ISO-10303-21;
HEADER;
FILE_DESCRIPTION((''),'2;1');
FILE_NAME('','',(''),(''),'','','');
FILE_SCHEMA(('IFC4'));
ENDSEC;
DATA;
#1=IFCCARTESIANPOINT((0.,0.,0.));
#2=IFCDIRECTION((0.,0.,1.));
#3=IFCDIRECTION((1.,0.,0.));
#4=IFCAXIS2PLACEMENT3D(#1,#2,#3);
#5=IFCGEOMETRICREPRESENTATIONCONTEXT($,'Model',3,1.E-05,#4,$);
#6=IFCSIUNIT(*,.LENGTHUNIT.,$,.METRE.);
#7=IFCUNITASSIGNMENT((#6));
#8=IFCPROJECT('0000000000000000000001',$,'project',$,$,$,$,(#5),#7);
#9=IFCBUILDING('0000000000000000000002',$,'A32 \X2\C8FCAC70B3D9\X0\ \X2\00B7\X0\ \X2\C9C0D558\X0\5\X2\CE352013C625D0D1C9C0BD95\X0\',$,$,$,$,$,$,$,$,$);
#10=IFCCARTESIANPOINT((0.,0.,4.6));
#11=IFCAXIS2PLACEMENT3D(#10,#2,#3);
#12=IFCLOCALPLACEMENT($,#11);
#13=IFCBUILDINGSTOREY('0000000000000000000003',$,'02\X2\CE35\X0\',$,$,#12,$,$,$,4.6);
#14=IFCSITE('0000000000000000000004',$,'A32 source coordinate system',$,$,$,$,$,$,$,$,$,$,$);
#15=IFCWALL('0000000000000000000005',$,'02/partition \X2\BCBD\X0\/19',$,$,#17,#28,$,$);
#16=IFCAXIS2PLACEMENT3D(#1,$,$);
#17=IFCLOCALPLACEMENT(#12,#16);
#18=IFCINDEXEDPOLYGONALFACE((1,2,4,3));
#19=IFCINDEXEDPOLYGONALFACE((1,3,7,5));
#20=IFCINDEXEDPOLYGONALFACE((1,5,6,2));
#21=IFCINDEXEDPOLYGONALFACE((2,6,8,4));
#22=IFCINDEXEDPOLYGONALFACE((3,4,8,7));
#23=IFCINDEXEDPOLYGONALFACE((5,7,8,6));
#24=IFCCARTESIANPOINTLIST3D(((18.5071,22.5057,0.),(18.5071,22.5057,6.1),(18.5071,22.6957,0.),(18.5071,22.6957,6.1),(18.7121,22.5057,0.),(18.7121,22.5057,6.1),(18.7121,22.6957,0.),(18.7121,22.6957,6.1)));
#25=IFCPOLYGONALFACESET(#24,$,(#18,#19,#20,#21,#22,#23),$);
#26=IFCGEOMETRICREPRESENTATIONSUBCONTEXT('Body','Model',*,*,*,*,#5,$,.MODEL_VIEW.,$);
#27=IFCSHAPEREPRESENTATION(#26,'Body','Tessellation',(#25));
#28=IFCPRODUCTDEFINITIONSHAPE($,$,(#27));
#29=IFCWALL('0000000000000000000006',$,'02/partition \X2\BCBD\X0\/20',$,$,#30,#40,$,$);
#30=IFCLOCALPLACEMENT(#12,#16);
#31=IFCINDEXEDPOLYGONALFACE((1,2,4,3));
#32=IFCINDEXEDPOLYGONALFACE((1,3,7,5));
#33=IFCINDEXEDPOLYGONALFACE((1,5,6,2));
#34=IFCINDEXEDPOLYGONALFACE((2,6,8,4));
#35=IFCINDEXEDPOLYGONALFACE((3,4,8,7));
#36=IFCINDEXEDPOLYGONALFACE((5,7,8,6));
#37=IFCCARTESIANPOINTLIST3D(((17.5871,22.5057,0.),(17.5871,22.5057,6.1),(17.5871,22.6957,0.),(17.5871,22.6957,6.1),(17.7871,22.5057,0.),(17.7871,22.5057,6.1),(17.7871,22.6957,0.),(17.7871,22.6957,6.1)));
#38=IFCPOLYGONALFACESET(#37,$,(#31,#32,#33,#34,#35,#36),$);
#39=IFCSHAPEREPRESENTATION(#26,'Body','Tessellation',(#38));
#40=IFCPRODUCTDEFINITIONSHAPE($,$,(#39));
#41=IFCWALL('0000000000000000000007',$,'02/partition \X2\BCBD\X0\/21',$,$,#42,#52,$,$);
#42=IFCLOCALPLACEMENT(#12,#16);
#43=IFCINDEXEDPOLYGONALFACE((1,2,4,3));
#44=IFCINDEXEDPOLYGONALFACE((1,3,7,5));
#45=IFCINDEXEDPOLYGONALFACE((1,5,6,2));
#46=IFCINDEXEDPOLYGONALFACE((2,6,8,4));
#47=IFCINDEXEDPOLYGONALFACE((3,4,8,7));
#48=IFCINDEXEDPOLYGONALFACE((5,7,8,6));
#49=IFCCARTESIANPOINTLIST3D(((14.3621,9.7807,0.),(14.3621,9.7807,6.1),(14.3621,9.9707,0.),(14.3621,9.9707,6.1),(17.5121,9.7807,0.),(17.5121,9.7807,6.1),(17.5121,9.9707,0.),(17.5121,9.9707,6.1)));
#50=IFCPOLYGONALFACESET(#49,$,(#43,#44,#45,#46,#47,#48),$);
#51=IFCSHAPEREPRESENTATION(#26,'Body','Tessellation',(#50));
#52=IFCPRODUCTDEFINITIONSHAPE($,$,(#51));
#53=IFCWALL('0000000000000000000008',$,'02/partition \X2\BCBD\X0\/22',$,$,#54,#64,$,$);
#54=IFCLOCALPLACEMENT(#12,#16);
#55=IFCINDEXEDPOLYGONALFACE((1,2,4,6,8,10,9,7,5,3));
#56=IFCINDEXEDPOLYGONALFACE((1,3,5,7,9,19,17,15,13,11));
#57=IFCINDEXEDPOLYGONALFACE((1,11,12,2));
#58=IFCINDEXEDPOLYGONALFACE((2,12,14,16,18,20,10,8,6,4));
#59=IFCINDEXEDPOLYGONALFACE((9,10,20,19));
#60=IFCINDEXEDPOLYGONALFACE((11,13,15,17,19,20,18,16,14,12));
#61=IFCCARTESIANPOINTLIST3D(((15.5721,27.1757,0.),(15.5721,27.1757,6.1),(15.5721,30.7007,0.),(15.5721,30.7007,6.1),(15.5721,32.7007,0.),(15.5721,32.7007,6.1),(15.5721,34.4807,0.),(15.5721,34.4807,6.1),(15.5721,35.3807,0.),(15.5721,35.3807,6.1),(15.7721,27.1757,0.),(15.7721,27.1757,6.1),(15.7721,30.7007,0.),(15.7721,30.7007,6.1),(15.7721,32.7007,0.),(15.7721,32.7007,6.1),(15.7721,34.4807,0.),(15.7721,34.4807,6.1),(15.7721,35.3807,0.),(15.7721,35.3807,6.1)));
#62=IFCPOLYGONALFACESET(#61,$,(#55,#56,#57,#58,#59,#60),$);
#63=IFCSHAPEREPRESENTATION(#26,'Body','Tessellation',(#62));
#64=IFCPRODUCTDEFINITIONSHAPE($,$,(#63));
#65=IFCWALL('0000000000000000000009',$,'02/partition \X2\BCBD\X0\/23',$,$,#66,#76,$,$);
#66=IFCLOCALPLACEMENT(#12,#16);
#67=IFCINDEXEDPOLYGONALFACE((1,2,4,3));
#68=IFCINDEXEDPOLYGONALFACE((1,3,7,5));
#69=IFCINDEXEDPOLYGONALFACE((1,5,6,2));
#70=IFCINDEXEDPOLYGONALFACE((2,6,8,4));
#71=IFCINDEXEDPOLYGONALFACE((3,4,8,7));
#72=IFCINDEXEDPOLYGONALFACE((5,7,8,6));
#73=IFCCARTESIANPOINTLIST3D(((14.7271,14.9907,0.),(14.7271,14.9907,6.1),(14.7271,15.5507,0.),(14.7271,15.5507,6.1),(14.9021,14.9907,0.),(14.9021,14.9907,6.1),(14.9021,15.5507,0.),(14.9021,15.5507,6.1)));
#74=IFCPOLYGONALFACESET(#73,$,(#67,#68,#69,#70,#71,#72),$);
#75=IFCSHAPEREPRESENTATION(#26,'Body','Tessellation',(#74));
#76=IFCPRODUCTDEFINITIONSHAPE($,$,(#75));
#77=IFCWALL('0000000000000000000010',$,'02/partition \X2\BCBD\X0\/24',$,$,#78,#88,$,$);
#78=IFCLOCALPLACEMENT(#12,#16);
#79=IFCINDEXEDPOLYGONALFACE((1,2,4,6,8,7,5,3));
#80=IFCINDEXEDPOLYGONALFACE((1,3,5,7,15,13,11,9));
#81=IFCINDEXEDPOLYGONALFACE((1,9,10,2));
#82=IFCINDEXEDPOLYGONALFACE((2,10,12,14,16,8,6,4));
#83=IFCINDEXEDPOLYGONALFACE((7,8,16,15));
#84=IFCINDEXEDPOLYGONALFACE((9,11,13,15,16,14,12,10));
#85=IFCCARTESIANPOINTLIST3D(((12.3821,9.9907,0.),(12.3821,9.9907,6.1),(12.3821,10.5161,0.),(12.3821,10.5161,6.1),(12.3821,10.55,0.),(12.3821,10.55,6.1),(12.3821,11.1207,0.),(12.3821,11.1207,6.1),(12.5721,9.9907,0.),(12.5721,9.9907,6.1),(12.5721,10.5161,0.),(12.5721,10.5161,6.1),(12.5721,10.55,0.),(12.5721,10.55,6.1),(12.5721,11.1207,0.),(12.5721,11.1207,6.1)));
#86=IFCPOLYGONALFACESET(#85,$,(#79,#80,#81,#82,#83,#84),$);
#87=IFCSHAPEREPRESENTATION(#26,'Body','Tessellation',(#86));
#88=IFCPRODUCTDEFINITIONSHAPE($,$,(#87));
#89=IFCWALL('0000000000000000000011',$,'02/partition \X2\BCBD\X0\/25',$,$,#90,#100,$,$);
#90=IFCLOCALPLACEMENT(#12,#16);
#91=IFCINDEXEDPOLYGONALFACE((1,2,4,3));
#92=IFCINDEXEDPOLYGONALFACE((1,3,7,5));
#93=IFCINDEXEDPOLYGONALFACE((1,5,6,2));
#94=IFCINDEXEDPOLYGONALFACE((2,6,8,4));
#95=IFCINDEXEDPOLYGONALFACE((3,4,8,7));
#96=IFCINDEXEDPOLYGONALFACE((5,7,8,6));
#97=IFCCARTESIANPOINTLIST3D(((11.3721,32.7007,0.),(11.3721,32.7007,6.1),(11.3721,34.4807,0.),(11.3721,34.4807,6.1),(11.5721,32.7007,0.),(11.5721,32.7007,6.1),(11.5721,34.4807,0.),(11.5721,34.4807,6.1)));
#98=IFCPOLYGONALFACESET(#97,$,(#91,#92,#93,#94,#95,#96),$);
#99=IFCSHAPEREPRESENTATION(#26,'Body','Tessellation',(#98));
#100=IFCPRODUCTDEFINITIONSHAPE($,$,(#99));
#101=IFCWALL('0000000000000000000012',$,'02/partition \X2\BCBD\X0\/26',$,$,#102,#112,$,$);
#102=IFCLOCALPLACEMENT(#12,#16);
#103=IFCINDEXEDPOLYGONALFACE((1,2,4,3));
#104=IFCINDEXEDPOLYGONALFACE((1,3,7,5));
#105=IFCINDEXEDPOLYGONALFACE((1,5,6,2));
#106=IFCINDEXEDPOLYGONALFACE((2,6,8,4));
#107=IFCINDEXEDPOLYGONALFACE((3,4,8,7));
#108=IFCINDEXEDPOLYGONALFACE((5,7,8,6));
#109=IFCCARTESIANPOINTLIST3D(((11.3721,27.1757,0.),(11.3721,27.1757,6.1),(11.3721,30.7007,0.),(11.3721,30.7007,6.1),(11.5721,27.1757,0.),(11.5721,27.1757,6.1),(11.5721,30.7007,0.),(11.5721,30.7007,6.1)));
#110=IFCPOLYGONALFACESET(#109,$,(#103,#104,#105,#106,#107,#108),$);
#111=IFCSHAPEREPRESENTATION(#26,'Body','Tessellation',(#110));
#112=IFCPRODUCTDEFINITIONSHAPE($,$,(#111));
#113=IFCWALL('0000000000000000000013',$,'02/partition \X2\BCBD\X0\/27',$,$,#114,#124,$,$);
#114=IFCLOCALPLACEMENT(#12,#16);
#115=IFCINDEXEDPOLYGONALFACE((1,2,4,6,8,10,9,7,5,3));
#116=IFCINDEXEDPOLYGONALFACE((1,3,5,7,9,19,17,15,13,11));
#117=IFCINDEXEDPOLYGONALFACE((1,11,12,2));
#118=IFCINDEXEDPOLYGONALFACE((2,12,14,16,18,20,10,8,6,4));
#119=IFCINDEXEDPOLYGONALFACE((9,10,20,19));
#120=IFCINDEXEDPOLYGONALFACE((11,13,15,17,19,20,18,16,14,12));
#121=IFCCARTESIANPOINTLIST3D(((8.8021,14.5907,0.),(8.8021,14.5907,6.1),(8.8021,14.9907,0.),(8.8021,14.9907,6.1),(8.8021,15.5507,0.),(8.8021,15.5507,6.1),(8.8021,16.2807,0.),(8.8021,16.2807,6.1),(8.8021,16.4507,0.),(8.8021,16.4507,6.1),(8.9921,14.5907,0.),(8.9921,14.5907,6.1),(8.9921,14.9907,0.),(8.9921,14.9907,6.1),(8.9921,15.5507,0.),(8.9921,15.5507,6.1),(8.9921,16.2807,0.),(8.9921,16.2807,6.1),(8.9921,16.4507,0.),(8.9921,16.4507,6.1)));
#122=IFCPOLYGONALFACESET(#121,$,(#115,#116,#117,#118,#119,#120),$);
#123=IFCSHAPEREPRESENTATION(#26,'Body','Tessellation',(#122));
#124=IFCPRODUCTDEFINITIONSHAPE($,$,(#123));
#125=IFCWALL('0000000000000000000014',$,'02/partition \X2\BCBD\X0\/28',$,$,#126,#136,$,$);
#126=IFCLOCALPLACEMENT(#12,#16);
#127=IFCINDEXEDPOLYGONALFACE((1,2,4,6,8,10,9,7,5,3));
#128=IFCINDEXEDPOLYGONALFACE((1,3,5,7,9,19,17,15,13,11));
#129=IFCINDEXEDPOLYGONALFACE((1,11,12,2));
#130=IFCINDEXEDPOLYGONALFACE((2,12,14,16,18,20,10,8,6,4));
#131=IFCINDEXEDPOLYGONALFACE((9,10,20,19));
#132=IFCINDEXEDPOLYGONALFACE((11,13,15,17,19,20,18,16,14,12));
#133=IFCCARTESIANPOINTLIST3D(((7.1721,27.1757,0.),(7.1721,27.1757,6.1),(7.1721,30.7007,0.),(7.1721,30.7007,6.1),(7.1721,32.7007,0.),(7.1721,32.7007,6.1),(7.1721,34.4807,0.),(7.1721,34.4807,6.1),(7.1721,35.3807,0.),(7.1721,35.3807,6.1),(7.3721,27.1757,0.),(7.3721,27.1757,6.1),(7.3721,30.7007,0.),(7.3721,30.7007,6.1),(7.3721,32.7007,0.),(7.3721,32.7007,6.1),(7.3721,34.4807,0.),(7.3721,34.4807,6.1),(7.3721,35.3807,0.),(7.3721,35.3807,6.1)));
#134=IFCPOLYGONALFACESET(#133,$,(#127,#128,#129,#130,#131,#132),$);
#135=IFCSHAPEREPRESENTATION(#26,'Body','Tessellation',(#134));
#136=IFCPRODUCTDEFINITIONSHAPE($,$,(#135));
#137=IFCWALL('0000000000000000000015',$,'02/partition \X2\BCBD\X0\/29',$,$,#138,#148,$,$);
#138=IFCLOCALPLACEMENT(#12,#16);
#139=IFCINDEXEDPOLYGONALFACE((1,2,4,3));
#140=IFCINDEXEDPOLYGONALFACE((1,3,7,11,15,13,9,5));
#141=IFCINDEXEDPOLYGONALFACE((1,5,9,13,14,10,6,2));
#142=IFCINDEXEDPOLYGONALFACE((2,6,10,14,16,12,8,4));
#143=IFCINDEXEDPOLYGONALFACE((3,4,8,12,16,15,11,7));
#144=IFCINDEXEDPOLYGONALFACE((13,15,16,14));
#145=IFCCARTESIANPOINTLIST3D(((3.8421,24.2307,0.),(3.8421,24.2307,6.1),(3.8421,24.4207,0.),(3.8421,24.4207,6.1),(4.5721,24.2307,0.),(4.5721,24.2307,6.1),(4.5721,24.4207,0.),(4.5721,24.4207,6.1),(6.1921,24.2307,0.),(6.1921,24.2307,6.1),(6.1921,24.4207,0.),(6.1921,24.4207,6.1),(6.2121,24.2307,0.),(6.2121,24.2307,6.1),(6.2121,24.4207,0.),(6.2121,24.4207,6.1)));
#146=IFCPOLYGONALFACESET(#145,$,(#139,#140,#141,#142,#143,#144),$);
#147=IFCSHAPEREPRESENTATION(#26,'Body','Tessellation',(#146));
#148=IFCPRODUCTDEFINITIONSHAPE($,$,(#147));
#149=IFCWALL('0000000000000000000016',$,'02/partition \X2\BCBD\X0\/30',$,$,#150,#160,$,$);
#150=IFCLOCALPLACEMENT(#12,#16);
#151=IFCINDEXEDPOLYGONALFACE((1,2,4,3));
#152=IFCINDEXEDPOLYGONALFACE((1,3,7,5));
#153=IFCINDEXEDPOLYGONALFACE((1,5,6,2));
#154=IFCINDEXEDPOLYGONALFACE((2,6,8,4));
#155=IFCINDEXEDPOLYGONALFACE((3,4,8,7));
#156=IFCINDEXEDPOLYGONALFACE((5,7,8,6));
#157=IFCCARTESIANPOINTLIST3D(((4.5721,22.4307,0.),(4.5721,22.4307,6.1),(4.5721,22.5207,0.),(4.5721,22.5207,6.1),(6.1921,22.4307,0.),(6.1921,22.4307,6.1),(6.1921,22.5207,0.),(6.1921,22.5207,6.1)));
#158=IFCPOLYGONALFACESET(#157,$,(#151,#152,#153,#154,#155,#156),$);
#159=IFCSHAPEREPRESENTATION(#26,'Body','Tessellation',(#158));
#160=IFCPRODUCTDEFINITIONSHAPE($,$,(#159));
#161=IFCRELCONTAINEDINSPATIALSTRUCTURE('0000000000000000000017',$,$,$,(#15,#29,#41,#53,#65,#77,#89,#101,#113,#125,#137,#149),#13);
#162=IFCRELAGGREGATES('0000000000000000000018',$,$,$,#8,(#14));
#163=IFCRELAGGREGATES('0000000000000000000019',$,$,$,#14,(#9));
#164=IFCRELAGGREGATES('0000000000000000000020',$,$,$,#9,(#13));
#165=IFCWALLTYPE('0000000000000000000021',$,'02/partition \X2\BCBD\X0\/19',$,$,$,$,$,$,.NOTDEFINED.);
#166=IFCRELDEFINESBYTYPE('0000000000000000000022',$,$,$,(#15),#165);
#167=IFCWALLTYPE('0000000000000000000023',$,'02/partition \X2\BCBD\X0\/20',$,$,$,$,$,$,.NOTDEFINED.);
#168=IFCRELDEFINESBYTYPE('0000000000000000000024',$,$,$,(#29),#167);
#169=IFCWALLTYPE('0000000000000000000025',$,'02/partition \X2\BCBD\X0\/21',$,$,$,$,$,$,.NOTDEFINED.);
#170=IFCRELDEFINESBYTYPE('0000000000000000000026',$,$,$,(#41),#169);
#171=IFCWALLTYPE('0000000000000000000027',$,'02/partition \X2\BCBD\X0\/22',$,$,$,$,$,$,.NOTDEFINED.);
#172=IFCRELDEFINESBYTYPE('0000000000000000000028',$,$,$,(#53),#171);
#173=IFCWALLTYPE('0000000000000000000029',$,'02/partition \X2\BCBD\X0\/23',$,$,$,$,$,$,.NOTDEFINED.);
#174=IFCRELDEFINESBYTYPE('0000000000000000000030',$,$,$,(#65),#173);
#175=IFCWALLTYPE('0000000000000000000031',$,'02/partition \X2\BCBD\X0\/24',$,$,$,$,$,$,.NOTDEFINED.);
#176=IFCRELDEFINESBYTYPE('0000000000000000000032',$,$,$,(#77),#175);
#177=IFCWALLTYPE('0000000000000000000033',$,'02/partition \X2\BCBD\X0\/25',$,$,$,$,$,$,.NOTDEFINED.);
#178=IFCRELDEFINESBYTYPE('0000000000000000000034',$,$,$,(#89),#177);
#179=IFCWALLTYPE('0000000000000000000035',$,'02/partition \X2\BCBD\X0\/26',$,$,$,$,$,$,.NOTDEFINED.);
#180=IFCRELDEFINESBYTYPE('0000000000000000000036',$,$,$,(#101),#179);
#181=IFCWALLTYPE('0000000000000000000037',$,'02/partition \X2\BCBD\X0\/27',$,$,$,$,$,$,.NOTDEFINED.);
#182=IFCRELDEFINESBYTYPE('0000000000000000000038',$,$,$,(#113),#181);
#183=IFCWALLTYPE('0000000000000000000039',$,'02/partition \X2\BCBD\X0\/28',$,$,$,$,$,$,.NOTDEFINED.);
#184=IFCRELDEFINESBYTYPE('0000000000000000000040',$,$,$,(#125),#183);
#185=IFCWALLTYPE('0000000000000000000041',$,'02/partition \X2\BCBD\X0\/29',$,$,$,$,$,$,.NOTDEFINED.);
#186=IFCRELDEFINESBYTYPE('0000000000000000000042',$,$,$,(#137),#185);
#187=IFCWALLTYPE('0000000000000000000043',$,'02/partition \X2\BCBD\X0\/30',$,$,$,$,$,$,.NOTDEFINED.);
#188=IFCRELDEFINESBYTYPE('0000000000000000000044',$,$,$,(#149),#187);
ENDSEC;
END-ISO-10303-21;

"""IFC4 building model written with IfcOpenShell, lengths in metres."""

from ifc_helpers import new_model, si_unit, frame, origin, origin_with_axes, place, context, subcontext, project, spatial, polyline, outline, extrude, source, transform, mapped, type_object, type_shapes, element, save


model = new_model("IFC4")

# Units and contexts
model_context = context("Model", 3, precision=1e-05, world=origin_with_axes())
body_context = subcontext(model_context, "Body", "Model", "MODEL_VIEW")
ifc_project = project(units=[si_unit("LENGTHUNIT", "METRE")], contexts=[model_context])

# Site, building, storey
site = spatial("IfcSite", under=ifc_project, Name="A32 source coordinate system")
building = spatial("IfcBuilding", under=site, Name="A32 주거동 · 지하5층–옥탑지붕")
storey_placement = place(None, frame((0.0, 0.0, 4.6), z_axis=(0.0, 0.0, 1.0), x_axis=(1.0, 0.0, 0.0)))
storey = spatial("IfcBuildingStorey", under=building, at=storey_placement, Name="02층", Elevation=4.6)

# Walls
wall_type_1 = type_object("IfcWallType", Name="02/partition 벽/19", PredefinedType="NOTDEFINED")
shared_shape_1 = source(origin(), body_context, "Body", "SweptSolid", [
    extrude(outline(polyline([(18.5071, 22.6957), (18.7121, 22.6957), (18.7121, 22.5057), (18.5071, 22.5057), (18.5071, 22.6957)])), origin(), (0.0, 0.0, 1.0), 6.1),
])
type_shapes(wall_type_1, [shared_shape_1])
wall_1_placement = place(storey_placement, origin_with_axes())
element("IfcWall", 1, at=wall_1_placement, inside=storey, type_object=wall_type_1, Name="02/partition 벽/19", context=body_context, shape_type="MappedRepresentation", body=[
    mapped(shared_shape_1, transform((0.0, 0.0, 0.0), scale=1.0)),
])
wall_type_2 = type_object("IfcWallType", Name="02/partition 벽/20", PredefinedType="NOTDEFINED")
shared_shape_2 = source(origin(), body_context, "Body", "SweptSolid", [
    extrude(outline(polyline([(17.7871, 22.6957), (17.7871, 22.5057), (17.5871, 22.5057), (17.5871, 22.6957), (17.7871, 22.6957)])), origin(), (0.0, 0.0, 1.0), 6.1),
])
type_shapes(wall_type_2, [shared_shape_2])
wall_2_placement = place(storey_placement, origin_with_axes())
element("IfcWall", 2, at=wall_2_placement, inside=storey, type_object=wall_type_2, Name="02/partition 벽/20", context=body_context, shape_type="MappedRepresentation", body=[
    mapped(shared_shape_2, transform((0.0, 0.0, 0.0), scale=1.0)),
])
wall_type_3 = type_object("IfcWallType", Name="02/partition 벽/21", PredefinedType="NOTDEFINED")
shared_shape_3 = source(origin(), body_context, "Body", "SweptSolid", [
    extrude(outline(polyline([(17.5121, 9.9707), (17.5121, 9.7807), (14.3621, 9.7807), (14.3621, 9.9707), (17.5121, 9.9707)])), origin(), (0.0, 0.0, 1.0), 6.1),
])
type_shapes(wall_type_3, [shared_shape_3])
wall_3_placement = place(storey_placement, origin_with_axes())
element("IfcWall", 3, at=wall_3_placement, inside=storey, type_object=wall_type_3, Name="02/partition 벽/21", context=body_context, shape_type="MappedRepresentation", body=[
    mapped(shared_shape_3, transform((0.0, 0.0, 0.0), scale=1.0)),
])
wall_type_4 = type_object("IfcWallType", Name="02/partition 벽/22", PredefinedType="NOTDEFINED")
shared_shape_4 = source(origin(), body_context, "Body", "SweptSolid", [
    extrude(outline(polyline([(15.5721, 34.4807), (15.5721, 35.3807), (15.7721, 35.3807), (15.7721, 34.4807), (15.7721, 32.7007), (15.7721, 30.7007), (15.7721, 27.1757), (15.5721, 27.1757), (15.5721, 30.7007), (15.5721, 32.7007), (15.5721, 34.4807)])), origin(), (0.0, 0.0, 1.0), 6.1),
])
type_shapes(wall_type_4, [shared_shape_4])
wall_4_placement = place(storey_placement, origin_with_axes())
element("IfcWall", 4, at=wall_4_placement, inside=storey, type_object=wall_type_4, Name="02/partition 벽/22", context=body_context, shape_type="MappedRepresentation", body=[
    mapped(shared_shape_4, transform((0.0, 0.0, 0.0), scale=1.0)),
])
wall_type_5 = type_object("IfcWallType", Name="02/partition 벽/23", PredefinedType="NOTDEFINED")
shared_shape_5 = source(origin(), body_context, "Body", "SweptSolid", [
    extrude(outline(polyline([(14.9021, 15.5507), (14.9021, 14.9907), (14.7271, 14.9907), (14.7271, 15.5507), (14.9021, 15.5507)])), origin(), (0.0, 0.0, 1.0), 6.1),
])
type_shapes(wall_type_5, [shared_shape_5])
wall_5_placement = place(storey_placement, origin_with_axes())
element("IfcWall", 5, at=wall_5_placement, inside=storey, type_object=wall_type_5, Name="02/partition 벽/23", context=body_context, shape_type="MappedRepresentation", body=[
    mapped(shared_shape_5, transform((0.0, 0.0, 0.0), scale=1.0)),
])
wall_type_6 = type_object("IfcWallType", Name="02/partition 벽/24", PredefinedType="NOTDEFINED")
shared_shape_6 = source(origin(), body_context, "Body", "SweptSolid", [
    extrude(outline(polyline([(12.5721, 11.1207), (12.5721, 10.55), (12.5721, 10.5161), (12.5721, 9.9907), (12.3821, 9.9907), (12.3821, 10.5161), (12.3821, 10.55), (12.3821, 11.1207), (12.5721, 11.1207)])), origin(), (0.0, 0.0, 1.0), 6.1),
])
type_shapes(wall_type_6, [shared_shape_6])
wall_6_placement = place(storey_placement, origin_with_axes())
element("IfcWall", 6, at=wall_6_placement, inside=storey, type_object=wall_type_6, Name="02/partition 벽/24", context=body_context, shape_type="MappedRepresentation", body=[
    mapped(shared_shape_6, transform((0.0, 0.0, 0.0), scale=1.0)),
])
wall_type_7 = type_object("IfcWallType", Name="02/partition 벽/25", PredefinedType="NOTDEFINED")
shared_shape_7 = source(origin(), body_context, "Body", "SweptSolid", [
    extrude(outline(polyline([(11.5721, 34.4807), (11.5721, 32.7007), (11.3721, 32.7007), (11.3721, 34.4807), (11.5721, 34.4807)])), origin(), (0.0, 0.0, 1.0), 6.1),
])
type_shapes(wall_type_7, [shared_shape_7])
wall_7_placement = place(storey_placement, origin_with_axes())
element("IfcWall", 7, at=wall_7_placement, inside=storey, type_object=wall_type_7, Name="02/partition 벽/25", context=body_context, shape_type="MappedRepresentation", body=[
    mapped(shared_shape_7, transform((0.0, 0.0, 0.0), scale=1.0)),
])
wall_type_8 = type_object("IfcWallType", Name="02/partition 벽/26", PredefinedType="NOTDEFINED")
shared_shape_8 = source(origin(), body_context, "Body", "SweptSolid", [
    extrude(outline(polyline([(11.3721, 30.7007), (11.5721, 30.7007), (11.5721, 27.1757), (11.3721, 27.1757), (11.3721, 30.7007)])), origin(), (0.0, 0.0, 1.0), 6.1),
])
type_shapes(wall_type_8, [shared_shape_8])
wall_8_placement = place(storey_placement, origin_with_axes())
element("IfcWall", 8, at=wall_8_placement, inside=storey, type_object=wall_type_8, Name="02/partition 벽/26", context=body_context, shape_type="MappedRepresentation", body=[
    mapped(shared_shape_8, transform((0.0, 0.0, 0.0), scale=1.0)),
])
wall_type_9 = type_object("IfcWallType", Name="02/partition 벽/27", PredefinedType="NOTDEFINED")
shared_shape_9 = source(origin(), body_context, "Body", "SweptSolid", [
    extrude(outline(polyline([(8.9921, 16.4507), (8.9921, 16.2807), (8.9921, 15.5507), (8.9921, 14.9907), (8.9921, 14.5907), (8.8021, 14.5907), (8.8021, 14.9907), (8.8021, 15.5507), (8.8021, 16.2807), (8.8021, 16.4507), (8.9921, 16.4507)])), origin(), (0.0, 0.0, 1.0), 6.1),
])
type_shapes(wall_type_9, [shared_shape_9])
wall_9_placement = place(storey_placement, origin_with_axes())
element("IfcWall", 9, at=wall_9_placement, inside=storey, type_object=wall_type_9, Name="02/partition 벽/27", context=body_context, shape_type="MappedRepresentation", body=[
    mapped(shared_shape_9, transform((0.0, 0.0, 0.0), scale=1.0)),
])
wall_type_10 = type_object("IfcWallType", Name="02/partition 벽/28", PredefinedType="NOTDEFINED")
shared_shape_10 = source(origin(), body_context, "Body", "SweptSolid", [
    extrude(outline(polyline([(7.1721, 32.7007), (7.1721, 34.4807), (7.1721, 35.3807), (7.3721, 35.3807), (7.3721, 34.4807), (7.3721, 32.7007), (7.3721, 30.7007), (7.3721, 27.1757), (7.1721, 27.1757), (7.1721, 30.7007), (7.1721, 32.7007)])), origin(), (0.0, 0.0, 1.0), 6.1),
])
type_shapes(wall_type_10, [shared_shape_10])
wall_10_placement = place(storey_placement, origin_with_axes())
element("IfcWall", 10, at=wall_10_placement, inside=storey, type_object=wall_type_10, Name="02/partition 벽/28", context=body_context, shape_type="MappedRepresentation", body=[
    mapped(shared_shape_10, transform((0.0, 0.0, 0.0), scale=1.0)),
])
wall_type_11 = type_object("IfcWallType", Name="02/partition 벽/29", PredefinedType="NOTDEFINED")
shared_shape_11 = source(origin(), body_context, "Body", "SweptSolid", [
    extrude(outline(polyline([(6.1921, 24.2307), (4.5721, 24.2307), (3.8421, 24.2307), (3.8421, 24.4207), (4.5721, 24.4207), (6.1921, 24.4207), (6.2121, 24.4207), (6.2121, 24.2307), (6.1921, 24.2307)])), origin(), (0.0, 0.0, 1.0), 6.1),
])
type_shapes(wall_type_11, [shared_shape_11])
wall_11_placement = place(storey_placement, origin_with_axes())
element("IfcWall", 11, at=wall_11_placement, inside=storey, type_object=wall_type_11, Name="02/partition 벽/29", context=body_context, shape_type="MappedRepresentation", body=[
    mapped(shared_shape_11, transform((0.0, 0.0, 0.0), scale=1.0)),
])
wall_type_12 = type_object("IfcWallType", Name="02/partition 벽/30", PredefinedType="NOTDEFINED")
shared_shape_12 = source(origin(), body_context, "Body", "SweptSolid", [
    extrude(outline(polyline([(6.1921, 22.5207), (6.1921, 22.4307), (4.5721, 22.4307), (4.5721, 22.5207), (6.1921, 22.5207)])), origin(), (0.0, 0.0, 1.0), 6.1),
])
type_shapes(wall_type_12, [shared_shape_12])
wall_12_placement = place(storey_placement, origin_with_axes())
element("IfcWall", 12, at=wall_12_placement, inside=storey, type_object=wall_type_12, Name="02/partition 벽/30", context=body_context, shape_type="MappedRepresentation", body=[
    mapped(shared_shape_12, transform((0.0, 0.0, 0.0), scale=1.0)),
])

save(model, "model.ifc")
